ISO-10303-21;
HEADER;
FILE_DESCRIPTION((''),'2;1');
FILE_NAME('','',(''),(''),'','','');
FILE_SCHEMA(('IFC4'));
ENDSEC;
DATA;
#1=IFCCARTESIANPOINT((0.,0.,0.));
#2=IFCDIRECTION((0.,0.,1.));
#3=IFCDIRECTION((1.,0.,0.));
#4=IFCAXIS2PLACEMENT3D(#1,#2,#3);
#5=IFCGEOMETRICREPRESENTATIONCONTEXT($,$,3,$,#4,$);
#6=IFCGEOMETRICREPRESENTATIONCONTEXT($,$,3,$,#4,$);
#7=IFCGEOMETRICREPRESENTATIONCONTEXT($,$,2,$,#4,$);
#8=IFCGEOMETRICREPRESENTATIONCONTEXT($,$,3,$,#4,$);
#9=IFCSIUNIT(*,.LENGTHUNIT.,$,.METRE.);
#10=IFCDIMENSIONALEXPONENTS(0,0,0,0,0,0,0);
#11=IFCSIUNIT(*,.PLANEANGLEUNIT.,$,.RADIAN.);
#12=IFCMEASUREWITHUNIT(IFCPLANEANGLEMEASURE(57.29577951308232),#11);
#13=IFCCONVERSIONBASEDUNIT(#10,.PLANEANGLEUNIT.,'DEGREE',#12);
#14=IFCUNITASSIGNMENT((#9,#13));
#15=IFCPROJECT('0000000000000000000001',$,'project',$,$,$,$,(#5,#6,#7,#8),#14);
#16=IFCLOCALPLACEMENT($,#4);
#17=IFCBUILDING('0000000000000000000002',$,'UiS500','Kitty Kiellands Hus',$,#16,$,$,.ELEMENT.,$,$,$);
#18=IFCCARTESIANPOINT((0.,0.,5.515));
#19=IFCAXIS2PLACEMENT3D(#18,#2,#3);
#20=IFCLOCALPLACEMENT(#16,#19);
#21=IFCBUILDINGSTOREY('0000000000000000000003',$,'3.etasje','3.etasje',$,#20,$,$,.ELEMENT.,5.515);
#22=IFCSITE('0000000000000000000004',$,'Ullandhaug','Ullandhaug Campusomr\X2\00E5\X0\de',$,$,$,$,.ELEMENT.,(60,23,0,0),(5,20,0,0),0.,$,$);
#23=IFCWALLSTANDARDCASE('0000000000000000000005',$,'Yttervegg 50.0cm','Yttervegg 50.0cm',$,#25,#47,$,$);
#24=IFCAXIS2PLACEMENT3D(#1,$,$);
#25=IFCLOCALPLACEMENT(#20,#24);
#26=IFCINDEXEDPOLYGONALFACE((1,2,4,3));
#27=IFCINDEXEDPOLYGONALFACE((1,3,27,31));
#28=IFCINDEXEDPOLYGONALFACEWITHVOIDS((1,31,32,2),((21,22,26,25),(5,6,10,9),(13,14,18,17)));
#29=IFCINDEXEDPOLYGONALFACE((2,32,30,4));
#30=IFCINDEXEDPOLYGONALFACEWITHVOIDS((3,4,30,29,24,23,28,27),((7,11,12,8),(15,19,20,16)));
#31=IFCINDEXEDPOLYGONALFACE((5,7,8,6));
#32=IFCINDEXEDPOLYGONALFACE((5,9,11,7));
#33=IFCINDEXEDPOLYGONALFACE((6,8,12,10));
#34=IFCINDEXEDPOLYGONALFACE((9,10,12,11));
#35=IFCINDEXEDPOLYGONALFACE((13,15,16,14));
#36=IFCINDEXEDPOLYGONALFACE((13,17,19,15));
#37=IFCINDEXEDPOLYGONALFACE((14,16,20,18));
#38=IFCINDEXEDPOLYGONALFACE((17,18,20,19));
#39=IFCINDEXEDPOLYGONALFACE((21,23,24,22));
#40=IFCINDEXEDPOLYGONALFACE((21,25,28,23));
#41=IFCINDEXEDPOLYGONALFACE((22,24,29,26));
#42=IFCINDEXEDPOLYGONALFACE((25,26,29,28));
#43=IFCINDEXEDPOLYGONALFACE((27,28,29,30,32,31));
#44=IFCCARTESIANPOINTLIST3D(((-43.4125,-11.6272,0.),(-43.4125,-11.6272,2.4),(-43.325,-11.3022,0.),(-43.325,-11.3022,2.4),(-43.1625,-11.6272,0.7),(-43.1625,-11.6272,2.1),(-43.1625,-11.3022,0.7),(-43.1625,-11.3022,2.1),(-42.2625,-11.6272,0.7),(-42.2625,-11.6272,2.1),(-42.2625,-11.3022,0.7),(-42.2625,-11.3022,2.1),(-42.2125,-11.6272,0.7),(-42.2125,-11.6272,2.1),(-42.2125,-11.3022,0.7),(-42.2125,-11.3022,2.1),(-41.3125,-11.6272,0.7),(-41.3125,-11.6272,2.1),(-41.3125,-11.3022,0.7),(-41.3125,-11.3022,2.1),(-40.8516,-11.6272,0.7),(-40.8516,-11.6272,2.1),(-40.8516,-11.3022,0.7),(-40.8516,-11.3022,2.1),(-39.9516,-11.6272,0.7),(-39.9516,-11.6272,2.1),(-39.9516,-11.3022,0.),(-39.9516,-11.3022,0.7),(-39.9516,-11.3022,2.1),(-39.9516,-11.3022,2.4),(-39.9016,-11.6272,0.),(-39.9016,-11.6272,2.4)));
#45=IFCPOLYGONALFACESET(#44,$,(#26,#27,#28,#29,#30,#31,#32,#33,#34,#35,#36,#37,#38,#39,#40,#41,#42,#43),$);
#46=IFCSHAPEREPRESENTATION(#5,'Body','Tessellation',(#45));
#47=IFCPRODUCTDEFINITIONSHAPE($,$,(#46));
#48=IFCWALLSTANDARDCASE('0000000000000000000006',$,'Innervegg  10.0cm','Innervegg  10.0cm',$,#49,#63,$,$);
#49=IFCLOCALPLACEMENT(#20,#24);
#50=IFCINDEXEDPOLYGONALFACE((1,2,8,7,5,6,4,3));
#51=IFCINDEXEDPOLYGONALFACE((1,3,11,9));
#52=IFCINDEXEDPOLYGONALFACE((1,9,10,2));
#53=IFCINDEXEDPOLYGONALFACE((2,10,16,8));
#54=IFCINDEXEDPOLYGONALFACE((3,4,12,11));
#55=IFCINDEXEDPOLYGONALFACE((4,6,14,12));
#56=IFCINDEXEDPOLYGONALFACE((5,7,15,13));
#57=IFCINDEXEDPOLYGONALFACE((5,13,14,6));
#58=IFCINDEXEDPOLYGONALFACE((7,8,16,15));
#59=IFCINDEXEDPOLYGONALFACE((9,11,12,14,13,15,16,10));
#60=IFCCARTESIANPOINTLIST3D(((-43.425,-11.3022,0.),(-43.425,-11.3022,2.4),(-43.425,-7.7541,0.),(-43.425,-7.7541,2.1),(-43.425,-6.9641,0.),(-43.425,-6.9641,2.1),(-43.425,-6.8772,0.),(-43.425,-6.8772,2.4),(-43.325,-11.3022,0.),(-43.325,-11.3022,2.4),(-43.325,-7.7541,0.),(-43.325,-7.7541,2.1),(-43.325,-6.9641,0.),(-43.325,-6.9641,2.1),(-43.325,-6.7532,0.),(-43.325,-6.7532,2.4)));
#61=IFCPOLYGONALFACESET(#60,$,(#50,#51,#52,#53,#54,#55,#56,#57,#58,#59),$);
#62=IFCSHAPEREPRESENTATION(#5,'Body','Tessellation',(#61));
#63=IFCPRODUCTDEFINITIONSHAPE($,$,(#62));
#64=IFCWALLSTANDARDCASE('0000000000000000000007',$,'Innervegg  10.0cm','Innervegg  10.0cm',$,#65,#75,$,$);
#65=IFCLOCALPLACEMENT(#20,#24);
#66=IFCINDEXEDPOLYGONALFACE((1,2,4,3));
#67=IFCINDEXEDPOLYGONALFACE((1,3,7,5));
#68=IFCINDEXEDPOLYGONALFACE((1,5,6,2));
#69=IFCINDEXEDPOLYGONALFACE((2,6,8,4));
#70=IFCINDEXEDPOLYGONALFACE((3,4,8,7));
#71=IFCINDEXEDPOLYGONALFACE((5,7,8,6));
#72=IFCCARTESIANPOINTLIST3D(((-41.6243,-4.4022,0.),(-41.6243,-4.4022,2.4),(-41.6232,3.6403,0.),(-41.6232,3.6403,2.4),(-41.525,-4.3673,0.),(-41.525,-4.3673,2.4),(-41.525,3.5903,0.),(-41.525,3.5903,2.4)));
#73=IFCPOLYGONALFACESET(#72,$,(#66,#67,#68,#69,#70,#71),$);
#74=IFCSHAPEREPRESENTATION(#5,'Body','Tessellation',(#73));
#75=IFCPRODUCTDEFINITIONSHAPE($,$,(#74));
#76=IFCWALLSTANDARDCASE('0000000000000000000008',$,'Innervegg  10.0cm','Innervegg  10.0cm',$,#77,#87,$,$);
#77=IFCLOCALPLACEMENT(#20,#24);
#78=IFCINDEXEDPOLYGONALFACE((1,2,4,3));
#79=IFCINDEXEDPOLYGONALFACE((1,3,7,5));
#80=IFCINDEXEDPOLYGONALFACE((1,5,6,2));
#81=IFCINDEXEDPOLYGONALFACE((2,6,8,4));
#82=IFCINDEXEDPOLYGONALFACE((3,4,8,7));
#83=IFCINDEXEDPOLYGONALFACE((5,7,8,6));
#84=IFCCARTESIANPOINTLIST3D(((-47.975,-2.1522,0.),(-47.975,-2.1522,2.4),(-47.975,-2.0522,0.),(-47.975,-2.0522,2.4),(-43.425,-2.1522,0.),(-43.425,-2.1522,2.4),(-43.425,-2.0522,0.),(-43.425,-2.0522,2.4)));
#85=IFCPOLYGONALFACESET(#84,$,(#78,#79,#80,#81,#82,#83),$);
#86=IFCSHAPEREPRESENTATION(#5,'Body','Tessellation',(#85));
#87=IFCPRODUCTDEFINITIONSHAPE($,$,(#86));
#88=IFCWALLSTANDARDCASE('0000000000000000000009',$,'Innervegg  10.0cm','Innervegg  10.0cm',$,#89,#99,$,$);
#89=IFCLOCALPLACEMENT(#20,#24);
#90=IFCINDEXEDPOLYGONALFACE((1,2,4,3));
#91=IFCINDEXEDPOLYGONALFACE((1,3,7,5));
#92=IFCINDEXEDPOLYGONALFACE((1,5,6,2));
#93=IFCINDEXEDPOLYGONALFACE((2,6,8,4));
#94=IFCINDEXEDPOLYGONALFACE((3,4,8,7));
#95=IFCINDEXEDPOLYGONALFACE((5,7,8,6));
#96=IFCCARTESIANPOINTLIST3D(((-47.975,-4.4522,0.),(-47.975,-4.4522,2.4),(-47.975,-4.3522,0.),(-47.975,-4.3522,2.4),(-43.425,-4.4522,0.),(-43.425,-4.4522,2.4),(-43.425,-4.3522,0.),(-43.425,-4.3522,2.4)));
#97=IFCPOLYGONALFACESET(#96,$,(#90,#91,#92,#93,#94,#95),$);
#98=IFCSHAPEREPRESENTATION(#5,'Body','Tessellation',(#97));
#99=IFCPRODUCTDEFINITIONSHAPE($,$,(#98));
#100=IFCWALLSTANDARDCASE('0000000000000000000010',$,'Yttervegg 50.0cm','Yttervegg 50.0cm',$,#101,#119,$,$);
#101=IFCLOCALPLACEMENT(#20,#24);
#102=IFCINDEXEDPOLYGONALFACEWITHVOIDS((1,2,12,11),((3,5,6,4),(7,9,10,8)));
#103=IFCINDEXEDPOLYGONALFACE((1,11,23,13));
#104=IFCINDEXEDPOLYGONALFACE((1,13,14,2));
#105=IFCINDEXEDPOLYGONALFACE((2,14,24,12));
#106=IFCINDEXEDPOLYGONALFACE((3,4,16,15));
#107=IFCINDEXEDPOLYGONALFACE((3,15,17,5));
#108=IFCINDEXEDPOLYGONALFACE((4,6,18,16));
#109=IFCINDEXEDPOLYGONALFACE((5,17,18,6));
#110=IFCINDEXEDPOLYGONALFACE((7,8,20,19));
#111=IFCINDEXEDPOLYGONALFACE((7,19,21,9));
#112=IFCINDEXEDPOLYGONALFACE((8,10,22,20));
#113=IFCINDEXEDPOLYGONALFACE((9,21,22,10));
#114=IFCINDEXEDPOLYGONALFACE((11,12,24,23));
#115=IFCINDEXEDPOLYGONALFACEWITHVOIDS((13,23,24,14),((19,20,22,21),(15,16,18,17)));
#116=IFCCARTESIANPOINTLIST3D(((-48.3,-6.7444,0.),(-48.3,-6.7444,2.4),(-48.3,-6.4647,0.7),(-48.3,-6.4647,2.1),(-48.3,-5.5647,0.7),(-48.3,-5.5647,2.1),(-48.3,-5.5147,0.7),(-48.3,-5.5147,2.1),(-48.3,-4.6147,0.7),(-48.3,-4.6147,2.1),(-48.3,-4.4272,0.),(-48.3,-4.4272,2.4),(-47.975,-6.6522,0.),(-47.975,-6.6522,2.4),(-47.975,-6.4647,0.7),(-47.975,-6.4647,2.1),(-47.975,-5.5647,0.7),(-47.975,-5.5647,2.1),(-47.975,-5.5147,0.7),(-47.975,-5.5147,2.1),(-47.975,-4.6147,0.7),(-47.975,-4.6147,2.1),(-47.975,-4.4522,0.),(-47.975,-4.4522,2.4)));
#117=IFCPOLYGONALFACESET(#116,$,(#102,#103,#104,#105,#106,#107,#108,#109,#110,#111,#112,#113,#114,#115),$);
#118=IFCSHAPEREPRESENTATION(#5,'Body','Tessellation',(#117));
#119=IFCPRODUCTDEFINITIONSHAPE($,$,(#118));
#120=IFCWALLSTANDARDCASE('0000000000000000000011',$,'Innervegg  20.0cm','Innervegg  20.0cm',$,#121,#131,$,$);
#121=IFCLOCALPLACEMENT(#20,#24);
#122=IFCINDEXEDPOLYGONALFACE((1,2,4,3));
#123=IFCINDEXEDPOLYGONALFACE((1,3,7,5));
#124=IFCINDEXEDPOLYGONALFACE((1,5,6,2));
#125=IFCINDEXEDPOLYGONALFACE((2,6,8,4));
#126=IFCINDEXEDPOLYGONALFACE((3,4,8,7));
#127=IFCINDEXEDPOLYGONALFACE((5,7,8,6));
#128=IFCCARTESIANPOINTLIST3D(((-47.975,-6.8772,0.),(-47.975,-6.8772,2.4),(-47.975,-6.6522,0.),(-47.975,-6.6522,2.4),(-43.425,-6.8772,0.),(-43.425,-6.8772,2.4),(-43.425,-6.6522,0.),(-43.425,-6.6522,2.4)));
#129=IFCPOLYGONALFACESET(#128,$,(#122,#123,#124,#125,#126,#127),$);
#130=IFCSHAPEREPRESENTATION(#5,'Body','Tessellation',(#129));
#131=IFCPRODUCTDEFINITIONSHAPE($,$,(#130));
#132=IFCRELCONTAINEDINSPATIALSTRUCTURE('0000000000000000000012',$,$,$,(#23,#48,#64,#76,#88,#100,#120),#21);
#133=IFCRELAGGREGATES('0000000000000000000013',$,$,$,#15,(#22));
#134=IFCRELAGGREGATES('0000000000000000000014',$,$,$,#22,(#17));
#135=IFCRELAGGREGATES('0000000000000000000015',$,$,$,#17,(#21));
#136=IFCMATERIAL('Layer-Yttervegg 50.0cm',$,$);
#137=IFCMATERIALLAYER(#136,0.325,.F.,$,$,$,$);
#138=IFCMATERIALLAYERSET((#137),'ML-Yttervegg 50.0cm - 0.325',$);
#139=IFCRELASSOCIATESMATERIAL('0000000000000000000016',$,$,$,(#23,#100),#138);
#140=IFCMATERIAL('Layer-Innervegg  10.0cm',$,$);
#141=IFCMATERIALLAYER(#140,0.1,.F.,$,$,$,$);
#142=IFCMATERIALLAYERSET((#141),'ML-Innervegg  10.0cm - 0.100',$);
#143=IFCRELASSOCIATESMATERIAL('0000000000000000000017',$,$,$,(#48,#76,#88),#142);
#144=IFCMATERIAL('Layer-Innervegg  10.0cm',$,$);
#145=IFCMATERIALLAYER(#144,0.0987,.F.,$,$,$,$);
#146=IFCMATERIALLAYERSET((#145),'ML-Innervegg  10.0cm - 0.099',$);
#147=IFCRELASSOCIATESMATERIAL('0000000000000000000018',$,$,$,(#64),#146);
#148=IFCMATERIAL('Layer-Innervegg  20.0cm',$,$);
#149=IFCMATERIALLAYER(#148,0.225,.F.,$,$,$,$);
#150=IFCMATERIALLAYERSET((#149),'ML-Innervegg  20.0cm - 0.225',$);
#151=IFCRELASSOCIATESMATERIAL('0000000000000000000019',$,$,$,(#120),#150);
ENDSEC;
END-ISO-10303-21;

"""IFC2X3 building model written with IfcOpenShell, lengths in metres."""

from ifc_helpers import new_model, entity, si_unit, converted_unit, frame, origin_with_axes, place, context, project, spatial, polyline, outline, extrude, material, layer, layer_set, layer_usage, element, save


model = new_model("IFC2X3")

# Units and contexts
context_of_model_1 = context(None, 3, world=origin_with_axes())
context_of_model_2 = context(None, 3, world=origin_with_axes())
context_of_model_3 = context(None, 2, world=origin_with_axes())
context_of_model_4 = context(None, 3, world=origin_with_axes())
ifc_project = project(units=[si_unit("LENGTHUNIT", "METRE"), converted_unit("PLANEANGLEUNIT", "DEGREE", entity("IfcPlaneAngleMeasure", 57.29577951308232), si_unit("PLANEANGLEUNIT", "RADIAN"), dimensions=[0, 0, 0, 0, 0, 0, 0])], contexts=[context_of_model_1, context_of_model_2, context_of_model_3, context_of_model_4])

# Site, building, storey
site = spatial("IfcSite", under=ifc_project, Name="Ullandhaug", Description="Ullandhaug Campusområde", CompositionType="ELEMENT", RefLatitude=(60, 23, 0, 0), RefLongitude=(5, 20, 0, 0), RefElevation=0.0)
building_placement = place(None, origin_with_axes())
building = spatial("IfcBuilding", under=site, at=building_placement, Name="UiS500", Description="Kitty Kiellands Hus", CompositionType="ELEMENT")
storey_placement = place(building_placement, frame((0.0, 0.0, 5.515), z_axis=(0.0, 0.0, 1.0), x_axis=(1.0, 0.0, 0.0)))
storey = spatial("IfcBuildingStorey", under=building, at=storey_placement, Name="3.etasje", Description="3.etasje", CompositionType="ELEMENT", Elevation=5.515)

# Shared definitions
ifc_material_1 = material(Name="Layer-Innervegg  10.0cm")
ifc_layer_1 = layer(ifc_material_1, 0.1, ventilated=False)
ifc_layer_set_1 = layer_set([ifc_layer_1], Name="ML-Innervegg  10.0cm - 0.100")
ifc_layer_usage_1 = layer_usage(ifc_layer_set_1, "AXIS2", "POSITIVE", 0.0)

# Wall, openings
ifc_material_2 = material(Name="Layer-Yttervegg 50.0cm")
ifc_layer_2 = layer(ifc_material_2, 0.325, ventilated=False)
ifc_layer_set_2 = layer_set([ifc_layer_2], Name="ML-Yttervegg 50.0cm - 0.325")
ifc_layer_usage_2 = layer_usage(ifc_layer_set_2, "AXIS2", "POSITIVE", 0.0)
wall_1_placement = place(storey_placement, frame((-43.4125, -11.6272, 0.0), z_axis=(0.0, 0.0, 1.0), x_axis=(1.0, 0.0, 0.0)))
wall_1 = element("IfcWallStandardCase", 1, at=wall_1_placement, inside=storey, material=ifc_layer_usage_2, Name="Yttervegg 50.0cm", Description="Yttervegg 50.0cm", context=context_of_model_1, shape_type="SweptSolid", body=[
    extrude(outline(polyline([(0.0, 0.0), (3.5109, 0.0), (3.4609, 0.325), (0.0875, 0.325), (0.0, 0.0)])), origin_with_axes(), (0.0, 0.0, 1.0), 2.4),
])
opening_1_placement = place(wall_1_placement, frame((0.25, 0.325, 0.7), z_axis=(0.0, 0.0, 1.0), x_axis=(1.0, 0.0, 0.0)))
element("IfcOpeningElement", 2, at=opening_1_placement, cuts=wall_1, context=context_of_model_1, shape_type="SweptSolid", body=[
    extrude(outline(polyline([(0.0, 0.0), (1.4, 0.0), (1.4, 0.9), (0.0, 0.9), (0.0, 0.0)])), frame((0.0, 0.0, 0.0), z_axis=(0.0, 1.0, 0.0), x_axis=(0.0, 0.0, 1.0)), (0.0, 0.0, -1.0), 0.325),
])
opening_2_placement = place(wall_1_placement, frame((1.2, 0.325, 0.7), z_axis=(0.0, 0.0, 1.0), x_axis=(1.0, 0.0, 0.0)))
element("IfcOpeningElement", 3, at=opening_2_placement, cuts=wall_1, context=context_of_model_1, shape_type="SweptSolid", body=[
    extrude(outline(polyline([(0.0, 0.0), (1.4, 0.0), (1.4, 0.9), (0.0, 0.9), (0.0, 0.0)])), frame((0.0, 0.0, 0.0), z_axis=(0.0, 1.0, 0.0), x_axis=(0.0, 0.0, 1.0)), (0.0, 0.0, -1.0), 0.325),
])
opening_3_placement = place(wall_1_placement, frame((2.5609, 0.325, 0.7), z_axis=(0.0, 0.0, 1.0), x_axis=(1.0, 0.0, 0.0)))
element("IfcOpeningElement", 4, at=opening_3_placement, cuts=wall_1, context=context_of_model_1, shape_type="SweptSolid", body=[
    extrude(outline(polyline([(0.0, 0.0), (1.4, 0.0), (1.4, 0.9), (0.0, 0.9), (0.0, 0.0)])), frame((0.0, 0.0, 0.0), z_axis=(0.0, 1.0, 0.0), x_axis=(0.0, 0.0, 1.0)), (0.0, 0.0, -1.0), 0.325),
])

# Wall, opening
wall_2_placement = place(storey_placement, frame((-43.425, -6.8772, 0.0), z_axis=(0.0, 0.0, 1.0), x_axis=(0.0, -1.0, 0.0)))
wall_2 = element("IfcWallStandardCase", 5, at=wall_2_placement, inside=storey, material=ifc_layer_usage_1, Name="Innervegg  10.0cm", Description="Innervegg  10.0cm", context=context_of_model_1, shape_type="SweptSolid", body=[
    extrude(outline(polyline([(0.0, 0.0), (4.425, 0.0), (4.425, 0.1), (-0.124, 0.1), (0.0, 0.0)])), frame((0.0, 0.0, 0.0), z_axis=(0.0, 0.0, 1.0), x_axis=(1.0, 0.0, 0.0)), (0.0, 0.0, 1.0), 2.4),
])
opening_4_placement = place(wall_2_placement, frame((0.0869, 0.1, 0.0), z_axis=(0.0, 0.0, 1.0), x_axis=(1.0, 0.0, 0.0)))
element("IfcOpeningElement", 6, at=opening_4_placement, cuts=wall_2, context=context_of_model_1, shape_type="SweptSolid", body=[
    extrude(outline(polyline([(0.0, 0.0), (2.1, 0.0), (2.1, 0.79), (0.0, 0.79), (0.0, 0.0)])), frame((0.0, 0.0, 0.0), z_axis=(0.0, 1.0, 0.0), x_axis=(0.0, 0.0, 1.0)), (0.0, 0.0, -1.0), 0.1),
])

# Walls
ifc_material_3 = material(Name="Layer-Innervegg  10.0cm")
ifc_layer_3 = layer(ifc_material_3, 0.0987, ventilated=False)
ifc_layer_set_3 = layer_set([ifc_layer_3], Name="ML-Innervegg  10.0cm - 0.099")
ifc_layer_usage_3 = layer_usage(ifc_layer_set_3, "AXIS2", "POSITIVE", 0.0)
wall_3_placement = place(storey_placement, frame((-41.525, -4.3673, 0.0), z_axis=(0.0, 0.0, 1.0), x_axis=(0.0, 1.0, 0.0)))
element("IfcWallStandardCase", 7, at=wall_3_placement, inside=storey, material=ifc_layer_usage_3, Name="Innervegg  10.0cm", Description="Innervegg  10.0cm", context=context_of_model_1, shape_type="SweptSolid", body=[
    extrude(outline(polyline([(0.0, 0.0), (7.9575, 0.0), (8.0075, 0.0982), (-0.035, 0.0993), (0.0, 0.0)])), frame((0.0, 0.0, 0.0), z_axis=(0.0, 0.0, 1.0), x_axis=(1.0, 0.0, 0.0)), (0.0, 0.0, 1.0), 2.4),
])
for number, where, z_axis, x_axis, name in (
    (8, (-47.975, -2.1522, 0.0), (0.0, 0.0, 1.0), (1.0, 0.0, 0.0), "Innervegg  10.0cm"),
    (9, (-47.975, -4.4522, 0.0), (0.0, 0.0, 1.0), (1.0, 0.0, 0.0), "Innervegg  10.0cm"),
):
    element("IfcWallStandardCase", number, at=place(storey_placement, frame(where, z_axis=z_axis, x_axis=x_axis)), inside=storey, material=ifc_layer_usage_1, Name=name, Description="Innervegg  10.0cm", context=context_of_model_1, shape_type="SweptSolid", body=[
        extrude(outline(polyline([(0.0, 0.0), (4.55, 0.0), (4.55, 0.1), (0.0, 0.1), (0.0, 0.0)])), origin_with_axes(), (0.0, 0.0, 1.0), 2.4),
    ])

# Wall, openings
wall_4_placement = place(storey_placement, frame((-48.3, -4.4272, 0.0), z_axis=(0.0, 0.0, 1.0), x_axis=(0.0, -1.0, 0.0)))
wall_4 = element("IfcWallStandardCase", 10, at=wall_4_placement, inside=storey, material=ifc_layer_usage_2, Name="Yttervegg 50.0cm", Description="Yttervegg 50.0cm", context=context_of_model_1, shape_type="SweptSolid", body=[
    extrude(outline(polyline([(0.0, 0.0), (2.3172, 0.0), (2.225, 0.325), (0.025, 0.325), (0.0, 0.0)])), frame((0.0, 0.0, 0.0), z_axis=(0.0, 0.0, 1.0), x_axis=(1.0, 0.0, 0.0)), (0.0, 0.0, 1.0), 2.4),
])
opening_5_placement = place(wall_4_placement, frame((0.1875, 0.325, 0.7), z_axis=(0.0, 0.0, 1.0), x_axis=(1.0, 0.0, 0.0)))
element("IfcOpeningElement", 11, at=opening_5_placement, cuts=wall_4, context=context_of_model_1, shape_type="SweptSolid", body=[
    extrude(outline(polyline([(0.0, 0.0), (1.4, 0.0), (1.4, 0.9), (0.0, 0.9), (0.0, 0.0)])), frame((0.0, 0.0, 0.0), z_axis=(0.0, 1.0, 0.0), x_axis=(0.0, 0.0, 1.0)), (0.0, 0.0, -1.0), 0.325),
])
opening_6_placement = place(wall_4_placement, frame((1.1375, 0.325, 0.7), z_axis=(0.0, 0.0, 1.0), x_axis=(1.0, 0.0, 0.0)))
element("IfcOpeningElement", 12, at=opening_6_placement, cuts=wall_4, context=context_of_model_1, shape_type="SweptSolid", body=[
    extrude(outline(polyline([(0.0, 0.0), (1.4, 0.0), (1.4, 0.9), (0.0, 0.9), (0.0, 0.0)])), frame((0.0, 0.0, 0.0), z_axis=(0.0, 1.0, 0.0), x_axis=(0.0, 0.0, 1.0)), (0.0, 0.0, -1.0), 0.325),
])

# Wall
ifc_material_4 = material(Name="Layer-Innervegg  20.0cm")
ifc_layer_4 = layer(ifc_material_4, 0.225, ventilated=False)
ifc_layer_set_4 = layer_set([ifc_layer_4], Name="ML-Innervegg  20.0cm - 0.225")
ifc_layer_usage_4 = layer_usage(ifc_layer_set_4, "AXIS2", "POSITIVE", 0.0)
wall_5_placement = place(storey_placement, frame((-47.975, -6.8772, 0.0), z_axis=(0.0, 0.0, 1.0), x_axis=(1.0, 0.0, 0.0)))
element("IfcWallStandardCase", 13, at=wall_5_placement, inside=storey, material=ifc_layer_usage_4, Name="Innervegg  20.0cm", Description="Innervegg  20.0cm", context=context_of_model_1, shape_type="SweptSolid", body=[
    extrude(outline(polyline([(0.0, 0.0), (4.55, 0.0), (4.55, 0.225), (0.0, 0.225), (0.0, 0.0)])), origin_with_axes(), (0.0, 0.0, 1.0), 2.4),
])

save(model, "model.ifc")
